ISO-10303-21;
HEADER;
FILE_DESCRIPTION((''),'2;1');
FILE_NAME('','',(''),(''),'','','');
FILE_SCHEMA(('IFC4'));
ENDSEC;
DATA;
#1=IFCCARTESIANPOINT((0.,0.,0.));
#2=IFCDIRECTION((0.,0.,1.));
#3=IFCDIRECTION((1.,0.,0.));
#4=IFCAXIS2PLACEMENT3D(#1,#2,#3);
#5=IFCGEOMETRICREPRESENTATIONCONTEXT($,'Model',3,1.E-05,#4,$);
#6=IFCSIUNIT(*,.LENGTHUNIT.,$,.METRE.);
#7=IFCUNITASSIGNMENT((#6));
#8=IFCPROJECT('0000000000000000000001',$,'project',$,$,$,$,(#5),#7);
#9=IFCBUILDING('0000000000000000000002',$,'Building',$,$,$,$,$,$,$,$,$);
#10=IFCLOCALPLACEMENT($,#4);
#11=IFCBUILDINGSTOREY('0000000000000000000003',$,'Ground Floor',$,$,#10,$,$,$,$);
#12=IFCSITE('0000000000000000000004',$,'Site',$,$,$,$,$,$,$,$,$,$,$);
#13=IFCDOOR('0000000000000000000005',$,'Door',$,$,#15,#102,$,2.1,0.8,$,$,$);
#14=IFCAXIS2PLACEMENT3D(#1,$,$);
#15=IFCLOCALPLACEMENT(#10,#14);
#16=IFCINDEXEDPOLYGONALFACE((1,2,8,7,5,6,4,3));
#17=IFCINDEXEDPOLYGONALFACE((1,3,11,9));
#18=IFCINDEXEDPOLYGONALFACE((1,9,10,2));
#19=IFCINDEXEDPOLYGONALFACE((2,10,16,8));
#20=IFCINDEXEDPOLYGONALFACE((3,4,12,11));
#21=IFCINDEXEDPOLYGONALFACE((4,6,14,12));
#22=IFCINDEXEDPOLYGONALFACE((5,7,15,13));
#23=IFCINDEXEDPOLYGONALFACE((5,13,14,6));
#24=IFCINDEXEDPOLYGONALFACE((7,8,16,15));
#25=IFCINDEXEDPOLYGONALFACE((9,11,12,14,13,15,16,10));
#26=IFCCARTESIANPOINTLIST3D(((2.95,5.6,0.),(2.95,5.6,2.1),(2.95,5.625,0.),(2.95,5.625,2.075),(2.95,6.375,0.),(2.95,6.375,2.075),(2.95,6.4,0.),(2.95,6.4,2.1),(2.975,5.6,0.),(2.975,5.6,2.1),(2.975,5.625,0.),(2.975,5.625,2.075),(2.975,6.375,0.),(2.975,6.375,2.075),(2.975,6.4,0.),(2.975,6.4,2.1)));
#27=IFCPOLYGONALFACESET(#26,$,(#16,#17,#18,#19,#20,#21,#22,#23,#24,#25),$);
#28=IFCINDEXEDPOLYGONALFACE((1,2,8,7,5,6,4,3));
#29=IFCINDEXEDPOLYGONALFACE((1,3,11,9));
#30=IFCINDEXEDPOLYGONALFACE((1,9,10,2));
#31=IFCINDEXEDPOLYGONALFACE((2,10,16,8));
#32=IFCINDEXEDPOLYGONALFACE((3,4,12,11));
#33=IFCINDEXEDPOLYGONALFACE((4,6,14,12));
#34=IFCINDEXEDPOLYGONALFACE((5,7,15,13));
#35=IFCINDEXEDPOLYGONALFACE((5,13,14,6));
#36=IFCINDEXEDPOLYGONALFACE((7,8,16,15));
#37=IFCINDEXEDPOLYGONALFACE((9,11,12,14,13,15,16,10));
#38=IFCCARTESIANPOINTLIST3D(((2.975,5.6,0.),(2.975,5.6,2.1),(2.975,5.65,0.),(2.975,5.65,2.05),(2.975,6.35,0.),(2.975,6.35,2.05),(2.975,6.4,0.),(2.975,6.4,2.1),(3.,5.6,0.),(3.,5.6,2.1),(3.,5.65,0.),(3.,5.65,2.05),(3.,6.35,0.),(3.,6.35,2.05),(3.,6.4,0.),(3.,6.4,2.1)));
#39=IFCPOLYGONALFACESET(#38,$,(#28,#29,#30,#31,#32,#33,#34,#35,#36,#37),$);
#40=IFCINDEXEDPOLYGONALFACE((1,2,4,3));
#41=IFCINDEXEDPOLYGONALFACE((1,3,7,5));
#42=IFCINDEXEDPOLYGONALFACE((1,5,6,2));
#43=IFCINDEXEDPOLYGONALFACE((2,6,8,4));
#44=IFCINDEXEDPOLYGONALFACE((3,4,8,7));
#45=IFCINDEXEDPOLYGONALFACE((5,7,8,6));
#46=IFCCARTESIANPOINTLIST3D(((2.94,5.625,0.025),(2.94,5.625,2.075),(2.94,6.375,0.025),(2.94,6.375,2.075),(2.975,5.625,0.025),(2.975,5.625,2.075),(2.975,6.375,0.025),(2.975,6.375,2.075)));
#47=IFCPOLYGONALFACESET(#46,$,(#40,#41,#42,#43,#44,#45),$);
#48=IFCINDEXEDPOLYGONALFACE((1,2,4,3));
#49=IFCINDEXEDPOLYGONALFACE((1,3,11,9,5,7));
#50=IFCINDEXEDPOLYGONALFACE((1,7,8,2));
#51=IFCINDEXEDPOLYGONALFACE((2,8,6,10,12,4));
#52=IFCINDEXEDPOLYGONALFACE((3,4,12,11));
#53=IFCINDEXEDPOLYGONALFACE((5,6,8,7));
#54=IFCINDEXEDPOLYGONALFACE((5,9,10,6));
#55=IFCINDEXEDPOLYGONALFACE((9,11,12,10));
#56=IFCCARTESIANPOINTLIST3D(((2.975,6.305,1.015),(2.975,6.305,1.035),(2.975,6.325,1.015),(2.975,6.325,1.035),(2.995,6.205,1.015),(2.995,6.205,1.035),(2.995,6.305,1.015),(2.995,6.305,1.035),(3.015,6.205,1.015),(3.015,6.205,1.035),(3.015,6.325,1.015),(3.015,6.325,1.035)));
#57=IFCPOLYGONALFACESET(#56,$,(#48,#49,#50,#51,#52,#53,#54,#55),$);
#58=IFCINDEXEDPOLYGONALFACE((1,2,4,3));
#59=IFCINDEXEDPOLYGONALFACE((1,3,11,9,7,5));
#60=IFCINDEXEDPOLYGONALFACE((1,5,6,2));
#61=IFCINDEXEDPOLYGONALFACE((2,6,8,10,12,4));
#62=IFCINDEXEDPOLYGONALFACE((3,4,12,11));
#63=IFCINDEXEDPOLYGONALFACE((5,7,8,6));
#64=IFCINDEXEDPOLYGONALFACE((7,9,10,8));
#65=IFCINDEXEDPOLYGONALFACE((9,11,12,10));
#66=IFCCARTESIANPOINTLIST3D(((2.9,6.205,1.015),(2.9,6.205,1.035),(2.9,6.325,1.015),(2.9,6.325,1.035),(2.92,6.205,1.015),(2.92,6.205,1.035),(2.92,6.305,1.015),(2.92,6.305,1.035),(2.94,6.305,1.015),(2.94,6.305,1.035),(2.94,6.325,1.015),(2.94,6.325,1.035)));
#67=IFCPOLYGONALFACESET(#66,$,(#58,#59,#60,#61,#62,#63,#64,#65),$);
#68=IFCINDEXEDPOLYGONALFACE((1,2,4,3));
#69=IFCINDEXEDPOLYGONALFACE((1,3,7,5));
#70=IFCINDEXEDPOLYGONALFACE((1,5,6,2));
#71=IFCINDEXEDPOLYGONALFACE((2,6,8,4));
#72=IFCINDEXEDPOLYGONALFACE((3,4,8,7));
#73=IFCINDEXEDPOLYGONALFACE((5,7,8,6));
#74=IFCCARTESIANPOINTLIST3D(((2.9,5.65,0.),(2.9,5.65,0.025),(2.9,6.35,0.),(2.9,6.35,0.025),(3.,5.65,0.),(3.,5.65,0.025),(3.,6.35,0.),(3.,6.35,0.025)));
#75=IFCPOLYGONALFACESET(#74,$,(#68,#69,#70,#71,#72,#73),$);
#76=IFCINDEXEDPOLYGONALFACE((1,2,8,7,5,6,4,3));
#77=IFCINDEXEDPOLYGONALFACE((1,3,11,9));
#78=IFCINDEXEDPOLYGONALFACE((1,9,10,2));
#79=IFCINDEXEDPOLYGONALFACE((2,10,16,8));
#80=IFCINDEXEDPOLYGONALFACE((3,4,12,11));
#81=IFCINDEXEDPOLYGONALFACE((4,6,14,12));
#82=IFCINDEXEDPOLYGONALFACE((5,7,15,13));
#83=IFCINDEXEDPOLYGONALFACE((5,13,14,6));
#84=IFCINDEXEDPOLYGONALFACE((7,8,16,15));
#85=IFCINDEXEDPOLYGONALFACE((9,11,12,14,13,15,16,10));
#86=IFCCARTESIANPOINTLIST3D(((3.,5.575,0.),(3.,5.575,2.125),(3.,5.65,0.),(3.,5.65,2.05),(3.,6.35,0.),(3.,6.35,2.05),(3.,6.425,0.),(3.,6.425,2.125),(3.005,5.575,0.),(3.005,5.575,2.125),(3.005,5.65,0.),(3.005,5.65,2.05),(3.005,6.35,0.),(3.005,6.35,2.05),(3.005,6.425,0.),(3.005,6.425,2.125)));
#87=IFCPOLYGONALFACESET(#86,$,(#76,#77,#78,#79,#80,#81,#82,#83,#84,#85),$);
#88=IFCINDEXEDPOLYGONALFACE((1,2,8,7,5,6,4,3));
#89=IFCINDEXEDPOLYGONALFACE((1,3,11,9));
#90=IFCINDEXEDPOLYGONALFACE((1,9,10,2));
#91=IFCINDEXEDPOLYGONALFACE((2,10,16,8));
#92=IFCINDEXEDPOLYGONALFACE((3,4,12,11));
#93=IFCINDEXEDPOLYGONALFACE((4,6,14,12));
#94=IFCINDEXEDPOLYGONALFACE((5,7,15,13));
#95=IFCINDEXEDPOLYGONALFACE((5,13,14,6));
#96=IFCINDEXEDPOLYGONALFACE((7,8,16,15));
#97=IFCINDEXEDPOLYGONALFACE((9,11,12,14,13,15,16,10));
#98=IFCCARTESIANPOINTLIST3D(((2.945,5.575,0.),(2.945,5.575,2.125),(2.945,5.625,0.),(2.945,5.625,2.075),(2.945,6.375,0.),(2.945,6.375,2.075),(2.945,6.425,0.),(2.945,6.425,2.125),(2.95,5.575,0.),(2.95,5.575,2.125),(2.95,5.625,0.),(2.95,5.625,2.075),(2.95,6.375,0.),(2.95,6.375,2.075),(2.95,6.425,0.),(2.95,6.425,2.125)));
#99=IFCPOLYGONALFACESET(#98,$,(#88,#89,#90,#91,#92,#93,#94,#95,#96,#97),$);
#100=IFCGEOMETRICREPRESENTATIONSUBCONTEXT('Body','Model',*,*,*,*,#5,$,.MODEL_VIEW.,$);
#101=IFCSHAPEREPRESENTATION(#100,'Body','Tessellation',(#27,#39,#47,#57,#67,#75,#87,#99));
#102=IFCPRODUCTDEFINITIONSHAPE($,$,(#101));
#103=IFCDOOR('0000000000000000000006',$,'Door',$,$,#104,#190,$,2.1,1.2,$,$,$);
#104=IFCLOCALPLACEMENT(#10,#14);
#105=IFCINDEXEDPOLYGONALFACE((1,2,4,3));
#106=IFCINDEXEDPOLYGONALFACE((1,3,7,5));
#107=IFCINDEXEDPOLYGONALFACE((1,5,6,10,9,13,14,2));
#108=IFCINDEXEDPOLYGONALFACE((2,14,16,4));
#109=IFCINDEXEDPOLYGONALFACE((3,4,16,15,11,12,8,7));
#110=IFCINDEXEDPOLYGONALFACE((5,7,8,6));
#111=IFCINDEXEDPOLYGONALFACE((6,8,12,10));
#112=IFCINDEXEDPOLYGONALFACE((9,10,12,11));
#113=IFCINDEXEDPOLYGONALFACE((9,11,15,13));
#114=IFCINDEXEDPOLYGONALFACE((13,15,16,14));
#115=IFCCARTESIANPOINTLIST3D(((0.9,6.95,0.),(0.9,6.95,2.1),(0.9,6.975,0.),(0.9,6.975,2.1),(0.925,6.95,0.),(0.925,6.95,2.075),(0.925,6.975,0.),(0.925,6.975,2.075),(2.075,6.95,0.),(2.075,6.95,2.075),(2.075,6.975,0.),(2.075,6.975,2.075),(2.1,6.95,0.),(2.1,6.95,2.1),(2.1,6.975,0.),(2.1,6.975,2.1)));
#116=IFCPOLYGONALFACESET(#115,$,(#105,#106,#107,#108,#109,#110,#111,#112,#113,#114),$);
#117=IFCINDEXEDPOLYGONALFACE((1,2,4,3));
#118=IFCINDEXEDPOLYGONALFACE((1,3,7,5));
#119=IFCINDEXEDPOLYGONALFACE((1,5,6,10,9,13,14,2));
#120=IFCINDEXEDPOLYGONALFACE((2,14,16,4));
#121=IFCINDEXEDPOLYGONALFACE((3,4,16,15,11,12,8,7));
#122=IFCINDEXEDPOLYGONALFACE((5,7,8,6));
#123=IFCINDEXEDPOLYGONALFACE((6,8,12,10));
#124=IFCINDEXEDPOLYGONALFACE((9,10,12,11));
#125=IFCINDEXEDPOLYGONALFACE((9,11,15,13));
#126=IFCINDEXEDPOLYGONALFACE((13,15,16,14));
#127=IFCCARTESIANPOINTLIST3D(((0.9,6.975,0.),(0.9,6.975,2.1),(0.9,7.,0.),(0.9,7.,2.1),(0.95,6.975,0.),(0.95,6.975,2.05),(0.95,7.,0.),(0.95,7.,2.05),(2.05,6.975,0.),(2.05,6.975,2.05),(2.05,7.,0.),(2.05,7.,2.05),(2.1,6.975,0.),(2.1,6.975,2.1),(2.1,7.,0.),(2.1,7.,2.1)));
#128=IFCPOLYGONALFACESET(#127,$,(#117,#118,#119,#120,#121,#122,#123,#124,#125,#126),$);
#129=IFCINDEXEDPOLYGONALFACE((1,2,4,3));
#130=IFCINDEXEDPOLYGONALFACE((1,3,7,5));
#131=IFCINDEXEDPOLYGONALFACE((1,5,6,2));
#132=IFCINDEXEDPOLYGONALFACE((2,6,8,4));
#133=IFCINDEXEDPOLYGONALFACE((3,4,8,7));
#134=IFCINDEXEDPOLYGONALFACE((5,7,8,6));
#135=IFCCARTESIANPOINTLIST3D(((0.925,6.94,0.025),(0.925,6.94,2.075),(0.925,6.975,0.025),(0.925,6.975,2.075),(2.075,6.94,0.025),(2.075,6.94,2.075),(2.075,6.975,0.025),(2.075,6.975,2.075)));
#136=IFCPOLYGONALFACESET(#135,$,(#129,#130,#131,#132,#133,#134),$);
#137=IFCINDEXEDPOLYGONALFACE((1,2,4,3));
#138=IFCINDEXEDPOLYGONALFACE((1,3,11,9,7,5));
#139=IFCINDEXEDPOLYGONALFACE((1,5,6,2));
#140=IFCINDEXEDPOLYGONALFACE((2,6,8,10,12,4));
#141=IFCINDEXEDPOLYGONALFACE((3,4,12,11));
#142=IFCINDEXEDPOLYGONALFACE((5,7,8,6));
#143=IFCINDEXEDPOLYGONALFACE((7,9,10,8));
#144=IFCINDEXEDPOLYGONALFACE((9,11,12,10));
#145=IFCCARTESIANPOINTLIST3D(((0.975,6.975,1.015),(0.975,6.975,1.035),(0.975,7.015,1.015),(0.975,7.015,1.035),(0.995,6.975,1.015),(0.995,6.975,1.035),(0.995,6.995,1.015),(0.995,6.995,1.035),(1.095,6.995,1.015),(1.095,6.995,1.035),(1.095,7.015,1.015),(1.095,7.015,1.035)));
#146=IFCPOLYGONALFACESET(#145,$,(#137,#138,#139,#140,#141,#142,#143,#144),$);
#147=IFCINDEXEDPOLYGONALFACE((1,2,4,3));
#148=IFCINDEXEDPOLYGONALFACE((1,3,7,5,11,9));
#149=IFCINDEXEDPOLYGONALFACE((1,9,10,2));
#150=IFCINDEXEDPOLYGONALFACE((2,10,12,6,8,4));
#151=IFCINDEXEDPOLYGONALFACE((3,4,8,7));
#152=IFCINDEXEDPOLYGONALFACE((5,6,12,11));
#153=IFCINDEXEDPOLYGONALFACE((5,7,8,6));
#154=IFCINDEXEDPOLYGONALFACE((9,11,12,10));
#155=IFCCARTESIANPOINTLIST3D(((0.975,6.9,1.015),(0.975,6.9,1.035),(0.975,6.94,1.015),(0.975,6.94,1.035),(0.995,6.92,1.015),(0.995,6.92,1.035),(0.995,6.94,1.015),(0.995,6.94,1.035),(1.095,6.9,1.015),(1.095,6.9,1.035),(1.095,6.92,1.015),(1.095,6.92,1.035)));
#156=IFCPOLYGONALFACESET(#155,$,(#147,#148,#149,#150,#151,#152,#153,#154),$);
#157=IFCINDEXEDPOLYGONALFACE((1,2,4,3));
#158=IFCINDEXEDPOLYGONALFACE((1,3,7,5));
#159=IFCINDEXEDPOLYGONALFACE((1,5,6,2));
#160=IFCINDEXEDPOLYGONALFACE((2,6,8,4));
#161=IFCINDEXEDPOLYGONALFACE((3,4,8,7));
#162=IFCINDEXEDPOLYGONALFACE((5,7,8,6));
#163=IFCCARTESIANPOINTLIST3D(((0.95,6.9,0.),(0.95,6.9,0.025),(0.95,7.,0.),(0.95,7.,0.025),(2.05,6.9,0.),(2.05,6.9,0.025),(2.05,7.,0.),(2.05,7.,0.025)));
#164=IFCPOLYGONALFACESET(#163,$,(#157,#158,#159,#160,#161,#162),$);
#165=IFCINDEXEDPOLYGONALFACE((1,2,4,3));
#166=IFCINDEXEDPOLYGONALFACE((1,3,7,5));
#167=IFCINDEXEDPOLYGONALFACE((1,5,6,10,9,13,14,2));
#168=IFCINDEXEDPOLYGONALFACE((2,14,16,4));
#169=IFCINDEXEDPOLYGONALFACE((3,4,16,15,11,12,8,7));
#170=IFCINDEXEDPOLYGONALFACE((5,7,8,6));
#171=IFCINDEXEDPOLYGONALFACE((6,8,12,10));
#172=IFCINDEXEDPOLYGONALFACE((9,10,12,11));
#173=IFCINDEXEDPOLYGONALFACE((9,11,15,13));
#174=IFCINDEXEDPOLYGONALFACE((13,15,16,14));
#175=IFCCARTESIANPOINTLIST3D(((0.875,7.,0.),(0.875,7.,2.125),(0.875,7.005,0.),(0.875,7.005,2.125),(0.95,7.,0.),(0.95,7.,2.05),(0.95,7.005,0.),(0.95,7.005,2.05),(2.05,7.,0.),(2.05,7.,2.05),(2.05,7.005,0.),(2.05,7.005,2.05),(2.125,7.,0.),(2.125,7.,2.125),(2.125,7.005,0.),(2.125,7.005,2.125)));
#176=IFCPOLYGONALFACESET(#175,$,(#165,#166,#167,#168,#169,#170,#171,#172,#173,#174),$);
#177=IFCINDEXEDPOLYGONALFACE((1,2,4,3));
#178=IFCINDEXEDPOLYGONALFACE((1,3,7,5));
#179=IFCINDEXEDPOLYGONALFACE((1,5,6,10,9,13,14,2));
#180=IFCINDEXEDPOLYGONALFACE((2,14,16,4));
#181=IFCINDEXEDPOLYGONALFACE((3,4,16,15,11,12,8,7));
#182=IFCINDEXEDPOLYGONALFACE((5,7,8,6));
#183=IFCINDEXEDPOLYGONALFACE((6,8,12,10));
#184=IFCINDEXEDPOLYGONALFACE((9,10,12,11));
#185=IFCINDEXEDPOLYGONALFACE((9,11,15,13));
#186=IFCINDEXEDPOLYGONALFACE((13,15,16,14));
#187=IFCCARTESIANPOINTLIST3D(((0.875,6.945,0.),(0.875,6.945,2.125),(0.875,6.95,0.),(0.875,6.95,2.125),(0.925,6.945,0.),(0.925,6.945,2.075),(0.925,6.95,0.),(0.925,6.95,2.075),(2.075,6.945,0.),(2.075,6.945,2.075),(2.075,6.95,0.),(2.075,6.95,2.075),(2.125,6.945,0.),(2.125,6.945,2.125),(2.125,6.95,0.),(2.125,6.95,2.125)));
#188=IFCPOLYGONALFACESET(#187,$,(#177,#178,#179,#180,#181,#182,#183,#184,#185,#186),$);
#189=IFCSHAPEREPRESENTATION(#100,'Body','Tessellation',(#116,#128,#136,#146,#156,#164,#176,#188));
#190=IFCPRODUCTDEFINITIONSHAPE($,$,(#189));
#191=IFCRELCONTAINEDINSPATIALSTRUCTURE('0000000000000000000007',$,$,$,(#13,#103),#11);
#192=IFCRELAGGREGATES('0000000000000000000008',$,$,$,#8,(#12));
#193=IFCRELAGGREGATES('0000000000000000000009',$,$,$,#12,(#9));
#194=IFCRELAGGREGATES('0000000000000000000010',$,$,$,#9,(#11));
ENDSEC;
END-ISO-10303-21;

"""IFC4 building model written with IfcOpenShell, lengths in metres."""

from ifc_helpers import new_model, si_unit, frame, origin_with_axes, place, context, subcontext, project, spatial, line, indexed_curve, outline, extrude, element, save


model = new_model("IFC4")

# Units and contexts
model_context = context("Model", 3, precision=1e-05, world=origin_with_axes())
body_context = subcontext(model_context, "Body", "Model", "MODEL_VIEW")
ifc_project = project(units=[si_unit("LENGTHUNIT", "METRE")], contexts=[model_context])

# Site, building, storey
site = spatial("IfcSite", under=ifc_project, Name="Site")
building = spatial("IfcBuilding", under=site, Name="Building")
storey_placement = place(None, origin_with_axes())
storey = spatial("IfcBuildingStorey", under=building, at=storey_placement, Name="Ground Floor")

# Doors
door_1_placement = place(storey_placement, frame((3.0, 5.6, 0.0), z_axis=(0.0, 0.0, 1.0), x_axis=(0.0, 1.0, 0.0)))
element("IfcDoor", 1, at=door_1_placement, inside=storey, Name="Door", OverallHeight=2.1, OverallWidth=0.8, context=body_context, shape_type="SweptSolid", body=[
    extrude(outline(indexed_curve([(0.0, 0.0), (0.0, 2.1), (0.8, 2.1), (0.8, 0.0), (0.775, 0.0), (0.775, 2.075), (0.025, 2.075), (0.025, 0.0)], segments=[line(1, 2, 3, 4, 5, 6, 7, 8, 1)])), frame((0.0, 0.025, 0.0), z_axis=(0.0, -1.0, 0.0), x_axis=(1.0, 0.0, 0.0)), (0.0, 0.0, -1.0), 0.025),
    extrude(outline(indexed_curve([(0.0, 0.0), (0.0, 2.1), (0.8, 2.1), (0.8, 0.0), (0.75, 0.0), (0.75, 2.05), (0.05, 2.05), (0.05, 0.0)], segments=[line(1, 2, 3, 4, 5, 6, 7, 8, 1)])), frame((0.0, 0.0, 0.0), z_axis=(0.0, -1.0, 0.0), x_axis=(1.0, 0.0, 0.0)), (0.0, 0.0, -1.0), 0.025),
    extrude(outline(indexed_curve([(0.0, 0.0), (0.75, 0.0), (0.75, 0.035), (0.0, 0.035)], segments=[line(1, 2, 3, 4, 1)])), frame((0.025, 0.025, 0.025), z_axis=(0.0, 0.0, 1.0), x_axis=(1.0, 0.0, 0.0)), (0.0, 0.0, 1.0), 2.05),
    extrude(outline(indexed_curve([(0.0, 0.0), (0.0, -0.04), (-0.12, -0.04), (-0.12, -0.02), (-0.02, -0.02), (-0.02, 0.0)], segments=[line(1, 2, 3, 4, 5, 6, 1)])), frame((0.725, 0.025, 1.015), z_axis=(0.0, 0.0, 1.0), x_axis=(1.0, 0.0, 0.0)), (0.0, 0.0, 1.0), 0.02),
    extrude(outline(indexed_curve([(0.0, 0.0), (0.0, 0.04), (-0.12, 0.04), (-0.12, 0.02), (-0.02, 0.02), (-0.02, 0.0)], segments=[line(1, 2, 3, 4, 5, 6, 1)])), frame((0.725, 0.06, 1.015), z_axis=(0.0, 0.0, 1.0), x_axis=(1.0, 0.0, 0.0)), (0.0, 0.0, 1.0), 0.02),
    extrude(outline(indexed_curve([(0.0, 0.0), (0.7, 0.0), (0.7, 0.1), (0.0, 0.1)], segments=[line(1, 2, 3, 4, 1)])), frame((0.05, 0.0, 0.0), z_axis=(0.0, 0.0, 1.0), x_axis=(1.0, 0.0, 0.0)), (0.0, 0.0, 1.0), 0.025),
    extrude(outline(indexed_curve([(0.0, 0.0), (0.0, 2.125), (0.85, 2.125), (0.85, 0.0), (0.775, 0.0), (0.775, 2.05), (0.075, 2.05), (0.075, 0.0)], segments=[line(1, 2, 3, 4, 5, 6, 7, 8, 1)])), frame((-0.025, -0.005, 0.0), z_axis=(0.0, -1.0, 0.0), x_axis=(1.0, 0.0, 0.0)), (0.0, 0.0, -1.0), 0.005),
    extrude(outline(indexed_curve([(0.0, 0.0), (0.0, 2.125), (0.85, 2.125), (0.85, 0.0), (0.8, 0.0), (0.8, 2.075), (0.05, 2.075), (0.05, 0.0)], segments=[line(1, 2, 3, 4, 5, 6, 7, 8, 1)])), frame((-0.025, 0.05, 0.0), z_axis=(0.0, -1.0, 0.0), x_axis=(1.0, 0.0, 0.0)), (0.0, 0.0, -1.0), 0.005),
])
door_2_placement = place(storey_placement, frame((2.1, 7.0, 0.0), z_axis=(0.0, 0.0, 1.0), x_axis=(-1.0, 0.0, 0.0)))
element("IfcDoor", 2, at=door_2_placement, inside=storey, Name="Door", OverallHeight=2.1, OverallWidth=1.2, context=body_context, shape_type="SweptSolid", body=[
    extrude(outline(indexed_curve([(0.0, 0.0), (0.0, 2.1), (1.2, 2.1), (1.2, 0.0), (1.175, 0.0), (1.175, 2.075), (0.025, 2.075), (0.025, 0.0)], segments=[line(1, 2, 3, 4, 5, 6, 7, 8, 1)])), frame((0.0, 0.025, 0.0), z_axis=(0.0, -1.0, 0.0), x_axis=(1.0, 0.0, 0.0)), (0.0, 0.0, -1.0), 0.025),
    extrude(outline(indexed_curve([(0.0, 0.0), (0.0, 2.1), (1.2, 2.1), (1.2, 0.0), (1.15, 0.0), (1.15, 2.05), (0.05, 2.05), (0.05, 0.0)], segments=[line(1, 2, 3, 4, 5, 6, 7, 8, 1)])), frame((0.0, 0.0, 0.0), z_axis=(0.0, -1.0, 0.0), x_axis=(1.0, 0.0, 0.0)), (0.0, 0.0, -1.0), 0.025),
    extrude(outline(indexed_curve([(0.0, 0.0), (1.15, 0.0), (1.15, 0.035), (0.0, 0.035)], segments=[line(1, 2, 3, 4, 1)])), frame((0.025, 0.025, 0.025), z_axis=(0.0, 0.0, 1.0), x_axis=(1.0, 0.0, 0.0)), (0.0, 0.0, 1.0), 2.05),
    extrude(outline(indexed_curve([(0.0, 0.0), (0.0, -0.04), (-0.12, -0.04), (-0.12, -0.02), (-0.02, -0.02), (-0.02, 0.0)], segments=[line(1, 2, 3, 4, 5, 6, 1)])), frame((1.125, 0.025, 1.015), z_axis=(0.0, 0.0, 1.0), x_axis=(1.0, 0.0, 0.0)), (0.0, 0.0, 1.0), 0.02),
    extrude(outline(indexed_curve([(0.0, 0.0), (0.0, 0.04), (-0.12, 0.04), (-0.12, 0.02), (-0.02, 0.02), (-0.02, 0.0)], segments=[line(1, 2, 3, 4, 5, 6, 1)])), frame((1.125, 0.06, 1.015), z_axis=(0.0, 0.0, 1.0), x_axis=(1.0, 0.0, 0.0)), (0.0, 0.0, 1.0), 0.02),
    extrude(outline(indexed_curve([(0.0, 0.0), (1.1, 0.0), (1.1, 0.1), (0.0, 0.1)], segments=[line(1, 2, 3, 4, 1)])), frame((0.05, 0.0, 0.0), z_axis=(0.0, 0.0, 1.0), x_axis=(1.0, 0.0, 0.0)), (0.0, 0.0, 1.0), 0.025),
    extrude(outline(indexed_curve([(0.0, 0.0), (0.0, 2.125), (1.25, 2.125), (1.25, 0.0), (1.175, 0.0), (1.175, 2.05), (0.075, 2.05), (0.075, 0.0)], segments=[line(1, 2, 3, 4, 5, 6, 7, 8, 1)])), frame((-0.025, -0.005, 0.0), z_axis=(0.0, -1.0, 0.0), x_axis=(1.0, 0.0, 0.0)), (0.0, 0.0, -1.0), 0.005),
    extrude(outline(indexed_curve([(0.0, 0.0), (0.0, 2.125), (1.25, 2.125), (1.25, 0.0), (1.2, 0.0), (1.2, 2.075), (0.05, 2.075), (0.05, 0.0)], segments=[line(1, 2, 3, 4, 5, 6, 7, 8, 1)])), frame((-0.025, 0.05, 0.0), z_axis=(0.0, -1.0, 0.0), x_axis=(1.0, 0.0, 0.0)), (0.0, 0.0, -1.0), 0.005),
])

save(model, "model.ifc")
